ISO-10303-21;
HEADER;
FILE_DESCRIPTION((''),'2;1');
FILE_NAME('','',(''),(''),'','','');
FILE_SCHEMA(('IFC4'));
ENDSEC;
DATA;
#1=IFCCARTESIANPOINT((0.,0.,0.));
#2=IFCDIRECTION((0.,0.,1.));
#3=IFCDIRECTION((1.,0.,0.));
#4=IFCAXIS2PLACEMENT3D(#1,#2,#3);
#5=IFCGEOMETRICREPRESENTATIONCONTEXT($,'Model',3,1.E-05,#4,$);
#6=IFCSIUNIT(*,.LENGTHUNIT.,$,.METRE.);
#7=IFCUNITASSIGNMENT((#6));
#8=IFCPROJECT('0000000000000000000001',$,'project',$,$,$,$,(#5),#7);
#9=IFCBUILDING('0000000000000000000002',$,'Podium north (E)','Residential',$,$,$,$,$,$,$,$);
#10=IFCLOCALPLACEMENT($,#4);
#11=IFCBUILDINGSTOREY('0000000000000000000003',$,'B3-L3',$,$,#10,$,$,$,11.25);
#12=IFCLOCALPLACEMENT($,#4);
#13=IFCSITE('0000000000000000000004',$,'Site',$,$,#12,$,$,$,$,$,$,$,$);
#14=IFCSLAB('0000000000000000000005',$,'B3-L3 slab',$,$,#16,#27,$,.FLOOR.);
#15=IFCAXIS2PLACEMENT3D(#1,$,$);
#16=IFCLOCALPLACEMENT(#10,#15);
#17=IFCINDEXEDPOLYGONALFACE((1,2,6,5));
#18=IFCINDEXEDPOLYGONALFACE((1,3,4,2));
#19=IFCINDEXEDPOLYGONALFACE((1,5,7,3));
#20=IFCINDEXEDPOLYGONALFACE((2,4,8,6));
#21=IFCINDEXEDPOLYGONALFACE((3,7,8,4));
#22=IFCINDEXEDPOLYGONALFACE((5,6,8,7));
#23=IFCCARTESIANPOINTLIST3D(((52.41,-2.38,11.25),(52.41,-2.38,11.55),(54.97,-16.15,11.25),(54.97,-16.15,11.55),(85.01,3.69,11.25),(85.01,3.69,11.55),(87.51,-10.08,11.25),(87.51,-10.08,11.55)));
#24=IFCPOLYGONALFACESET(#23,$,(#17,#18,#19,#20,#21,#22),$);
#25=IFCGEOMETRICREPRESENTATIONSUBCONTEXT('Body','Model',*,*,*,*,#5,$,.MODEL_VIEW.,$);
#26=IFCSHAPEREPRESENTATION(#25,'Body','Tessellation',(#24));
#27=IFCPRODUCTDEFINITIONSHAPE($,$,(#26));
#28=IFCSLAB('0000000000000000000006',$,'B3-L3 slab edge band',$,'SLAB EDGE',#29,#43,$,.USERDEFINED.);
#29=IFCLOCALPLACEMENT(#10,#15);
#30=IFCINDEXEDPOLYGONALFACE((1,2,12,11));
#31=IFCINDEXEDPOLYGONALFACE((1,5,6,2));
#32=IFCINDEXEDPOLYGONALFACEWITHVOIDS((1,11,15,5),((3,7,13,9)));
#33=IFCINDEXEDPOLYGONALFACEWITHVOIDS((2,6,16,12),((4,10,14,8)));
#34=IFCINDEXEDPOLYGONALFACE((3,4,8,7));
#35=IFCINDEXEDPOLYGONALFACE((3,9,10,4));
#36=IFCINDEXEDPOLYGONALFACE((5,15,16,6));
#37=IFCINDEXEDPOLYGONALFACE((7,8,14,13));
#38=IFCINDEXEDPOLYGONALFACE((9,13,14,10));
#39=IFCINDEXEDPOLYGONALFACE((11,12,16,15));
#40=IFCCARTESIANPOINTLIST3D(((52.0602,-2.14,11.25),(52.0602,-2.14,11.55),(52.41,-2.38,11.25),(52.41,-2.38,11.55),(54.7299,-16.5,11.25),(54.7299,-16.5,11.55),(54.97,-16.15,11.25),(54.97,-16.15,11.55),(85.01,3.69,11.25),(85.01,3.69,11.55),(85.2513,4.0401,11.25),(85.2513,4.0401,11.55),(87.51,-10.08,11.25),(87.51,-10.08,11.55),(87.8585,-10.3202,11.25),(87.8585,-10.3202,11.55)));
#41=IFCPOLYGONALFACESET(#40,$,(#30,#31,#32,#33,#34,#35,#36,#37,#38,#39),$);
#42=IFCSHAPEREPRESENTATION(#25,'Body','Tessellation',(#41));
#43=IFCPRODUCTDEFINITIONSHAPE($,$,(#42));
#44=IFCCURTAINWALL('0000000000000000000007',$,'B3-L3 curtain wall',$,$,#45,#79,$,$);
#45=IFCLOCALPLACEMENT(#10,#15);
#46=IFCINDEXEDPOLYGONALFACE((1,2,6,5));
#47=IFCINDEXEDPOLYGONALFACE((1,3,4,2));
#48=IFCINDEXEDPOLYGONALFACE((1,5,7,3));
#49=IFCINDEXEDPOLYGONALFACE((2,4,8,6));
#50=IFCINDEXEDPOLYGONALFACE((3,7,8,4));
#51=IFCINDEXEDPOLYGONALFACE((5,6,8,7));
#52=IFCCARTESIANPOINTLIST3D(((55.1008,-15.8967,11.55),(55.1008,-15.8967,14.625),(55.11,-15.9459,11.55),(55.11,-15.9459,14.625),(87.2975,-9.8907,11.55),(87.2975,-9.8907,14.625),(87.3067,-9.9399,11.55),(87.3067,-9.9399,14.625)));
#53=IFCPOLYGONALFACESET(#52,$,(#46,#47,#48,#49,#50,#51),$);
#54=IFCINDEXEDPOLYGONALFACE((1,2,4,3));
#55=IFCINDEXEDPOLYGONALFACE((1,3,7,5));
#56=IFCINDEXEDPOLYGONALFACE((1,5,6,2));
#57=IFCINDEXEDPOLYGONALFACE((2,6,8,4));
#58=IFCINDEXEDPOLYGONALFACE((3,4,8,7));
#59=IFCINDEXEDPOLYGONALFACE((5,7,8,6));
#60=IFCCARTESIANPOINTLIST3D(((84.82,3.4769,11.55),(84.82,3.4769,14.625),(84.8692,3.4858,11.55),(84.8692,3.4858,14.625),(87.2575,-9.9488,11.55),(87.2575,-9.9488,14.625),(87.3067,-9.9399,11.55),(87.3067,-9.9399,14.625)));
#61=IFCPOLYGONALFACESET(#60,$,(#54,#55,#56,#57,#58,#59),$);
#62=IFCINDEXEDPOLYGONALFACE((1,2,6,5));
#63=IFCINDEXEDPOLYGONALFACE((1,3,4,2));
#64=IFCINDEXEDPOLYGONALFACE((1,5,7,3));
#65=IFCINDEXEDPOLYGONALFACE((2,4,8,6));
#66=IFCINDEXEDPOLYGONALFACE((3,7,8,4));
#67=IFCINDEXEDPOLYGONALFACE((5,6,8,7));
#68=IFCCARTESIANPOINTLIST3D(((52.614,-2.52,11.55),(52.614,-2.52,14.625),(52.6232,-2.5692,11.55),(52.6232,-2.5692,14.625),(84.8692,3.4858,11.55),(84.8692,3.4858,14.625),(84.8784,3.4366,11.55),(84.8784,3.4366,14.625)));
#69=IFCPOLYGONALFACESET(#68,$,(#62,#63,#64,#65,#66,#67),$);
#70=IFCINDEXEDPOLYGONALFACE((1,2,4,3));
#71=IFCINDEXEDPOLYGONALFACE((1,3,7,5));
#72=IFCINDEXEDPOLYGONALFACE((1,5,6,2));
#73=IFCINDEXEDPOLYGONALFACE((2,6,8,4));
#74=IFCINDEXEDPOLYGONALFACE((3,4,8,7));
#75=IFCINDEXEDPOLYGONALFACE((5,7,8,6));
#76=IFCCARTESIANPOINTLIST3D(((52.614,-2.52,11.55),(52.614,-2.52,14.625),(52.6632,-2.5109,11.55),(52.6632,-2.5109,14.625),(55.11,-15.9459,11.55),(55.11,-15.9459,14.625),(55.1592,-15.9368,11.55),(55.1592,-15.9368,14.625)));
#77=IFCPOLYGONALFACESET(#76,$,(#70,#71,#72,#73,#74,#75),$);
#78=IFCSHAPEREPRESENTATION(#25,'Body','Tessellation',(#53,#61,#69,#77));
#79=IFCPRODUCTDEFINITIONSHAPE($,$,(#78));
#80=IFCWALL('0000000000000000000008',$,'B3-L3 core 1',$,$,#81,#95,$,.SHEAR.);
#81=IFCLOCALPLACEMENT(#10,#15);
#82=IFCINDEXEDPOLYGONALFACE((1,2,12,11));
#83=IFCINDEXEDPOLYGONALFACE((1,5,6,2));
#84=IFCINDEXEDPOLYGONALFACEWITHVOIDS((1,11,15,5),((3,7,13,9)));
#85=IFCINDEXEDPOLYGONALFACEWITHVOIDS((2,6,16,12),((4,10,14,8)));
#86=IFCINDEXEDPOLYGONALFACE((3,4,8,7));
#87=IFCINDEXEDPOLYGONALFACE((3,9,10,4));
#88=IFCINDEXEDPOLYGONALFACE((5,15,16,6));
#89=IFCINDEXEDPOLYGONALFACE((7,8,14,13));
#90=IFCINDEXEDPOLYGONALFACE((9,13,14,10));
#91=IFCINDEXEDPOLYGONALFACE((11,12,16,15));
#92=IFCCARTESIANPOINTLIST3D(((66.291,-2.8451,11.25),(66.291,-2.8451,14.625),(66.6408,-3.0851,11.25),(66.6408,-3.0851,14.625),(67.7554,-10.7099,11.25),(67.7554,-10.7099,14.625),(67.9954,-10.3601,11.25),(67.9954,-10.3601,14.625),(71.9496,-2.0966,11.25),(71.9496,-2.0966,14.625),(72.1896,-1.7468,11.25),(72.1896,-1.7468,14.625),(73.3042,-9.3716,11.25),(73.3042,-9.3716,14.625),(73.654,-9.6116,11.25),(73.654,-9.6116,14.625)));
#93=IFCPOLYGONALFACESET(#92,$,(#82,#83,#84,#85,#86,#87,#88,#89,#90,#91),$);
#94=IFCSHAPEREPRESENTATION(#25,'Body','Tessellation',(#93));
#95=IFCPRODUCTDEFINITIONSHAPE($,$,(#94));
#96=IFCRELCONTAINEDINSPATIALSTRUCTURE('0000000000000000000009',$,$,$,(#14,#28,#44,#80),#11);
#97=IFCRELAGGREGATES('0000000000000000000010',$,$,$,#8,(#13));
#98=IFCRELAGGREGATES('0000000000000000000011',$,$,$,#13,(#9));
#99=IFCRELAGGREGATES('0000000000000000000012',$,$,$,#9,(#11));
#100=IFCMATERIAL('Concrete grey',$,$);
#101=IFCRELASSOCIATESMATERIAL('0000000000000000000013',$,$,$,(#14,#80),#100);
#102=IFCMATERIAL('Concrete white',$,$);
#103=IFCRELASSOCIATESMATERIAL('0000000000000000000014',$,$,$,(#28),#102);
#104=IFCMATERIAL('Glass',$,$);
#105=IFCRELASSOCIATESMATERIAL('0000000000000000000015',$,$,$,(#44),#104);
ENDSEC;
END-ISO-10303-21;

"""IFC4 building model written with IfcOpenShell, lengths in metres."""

from ifc_helpers import new_model, si_unit, frame, origin_with_axes, place, context, subcontext, project, spatial, polyline, outline, extrude, material, element, save


model = new_model("IFC4")

# Units and contexts
model_context = context("Model", 3, precision=1e-05, world=origin_with_axes())
body_context = subcontext(model_context, "Body", "Model", "MODEL_VIEW")
ifc_project = project(units=[si_unit("LENGTHUNIT", "METRE")], contexts=[model_context])

# Site, building, storey
site_placement = place(None, origin_with_axes())
site = spatial("IfcSite", under=ifc_project, at=site_placement, Name="Site")
building = spatial("IfcBuilding", under=site, Name="Podium north (E)", Description="Residential")
storey_placement = place(None, origin_with_axes())
storey = spatial("IfcBuildingStorey", under=building, at=storey_placement, Name="B3-L3", Elevation=11.25)

# Slabs
ifc_material_1 = material(Name="Concrete grey")
slab_1_placement = place(storey_placement, origin_with_axes())
element("IfcSlab", 1, at=slab_1_placement, inside=storey, material=ifc_material_1, Name="B3-L3 slab", PredefinedType="FLOOR", context=body_context, shape_type="SweptSolid", body=[
    extrude(outline(polyline([(54.97, -16.15), (87.51, -10.08), (85.01, 3.69), (52.41, -2.38), (54.97, -16.15)])), frame((0.0, 0.0, 11.25), z_axis=(0.0, 0.0, 1.0), x_axis=(1.0, 0.0, 0.0)), (0.0, 0.0, 1.0), 0.3),
])
ifc_material_2 = material(Name="Concrete white")
slab_2_placement = place(storey_placement, origin_with_axes())
element("IfcSlab", 2, at=slab_2_placement, inside=storey, material=ifc_material_2, Name="B3-L3 slab edge band", ObjectType="SLAB EDGE", PredefinedType="USERDEFINED", context=body_context, shape_type="SweptSolid", body=[
    extrude(outline(polyline([(54.7299, -16.5), (87.8585, -10.3202), (85.2513, 4.0401), (52.0602, -2.14), (54.7299, -16.5)]), holes=[polyline([(54.97, -16.15), (87.51, -10.08), (85.01, 3.69), (52.41, -2.38), (54.97, -16.15)])]), frame((0.0, 0.0, 11.25), z_axis=(0.0, 0.0, 1.0), x_axis=(1.0, 0.0, 0.0)), (0.0, 0.0, 1.0), 0.3),
])

# Curtain wall
ifc_material_3 = material(Name="Glass")
curtain_wall_placement = place(storey_placement, origin_with_axes())
element("IfcCurtainWall", 3, at=curtain_wall_placement, inside=storey, material=ifc_material_3, Name="B3-L3 curtain wall", context=body_context, shape_type="SweptSolid", body=[
    extrude(outline(polyline([(55.11, -15.9459), (87.3067, -9.9399), (87.2975, -9.8907), (55.1008, -15.8967), (55.11, -15.9459)])), frame((0.0, 0.0, 11.55), z_axis=(0.0, 0.0, 1.0), x_axis=(1.0, 0.0, 0.0)), (0.0, 0.0, 1.0), 3.075),
    extrude(outline(polyline([(87.3067, -9.9399), (84.8692, 3.4858), (84.82, 3.4769), (87.2575, -9.9488), (87.3067, -9.9399)])), frame((0.0, 0.0, 11.55), z_axis=(0.0, 0.0, 1.0), x_axis=(1.0, 0.0, 0.0)), (0.0, 0.0, 1.0), 3.075),
    extrude(outline(polyline([(84.8692, 3.4858), (52.614, -2.52), (52.6232, -2.5692), (84.8784, 3.4366), (84.8692, 3.4858)])), frame((0.0, 0.0, 11.55), z_axis=(0.0, 0.0, 1.0), x_axis=(1.0, 0.0, 0.0)), (0.0, 0.0, 1.0), 3.075),
    extrude(outline(polyline([(52.614, -2.52), (55.11, -15.9459), (55.1592, -15.9368), (52.6632, -2.5109), (52.614, -2.52)])), frame((0.0, 0.0, 11.55), z_axis=(0.0, 0.0, 1.0), x_axis=(1.0, 0.0, 0.0)), (0.0, 0.0, 1.0), 3.075),
])

# Wall
wall_placement = place(storey_placement, origin_with_axes())
element("IfcWall", 4, at=wall_placement, inside=storey, material=ifc_material_1, Name="B3-L3 core 1", PredefinedType="SHEAR", context=body_context, shape_type="SweptSolid", body=[
    extrude(outline(polyline([(72.1896, -1.7468), (66.291, -2.8451), (67.7554, -10.7099), (73.654, -9.6116), (72.1896, -1.7468)]), holes=[polyline([(71.9496, -2.0966), (66.6408, -3.0851), (67.9954, -10.3601), (73.3042, -9.3716), (71.9496, -2.0966)])]), frame((0.0, 0.0, 11.25), z_axis=(0.0, 0.0, 1.0), x_axis=(1.0, 0.0, 0.0)), (0.0, 0.0, 1.0), 3.375),
])

save(model, "model.ifc")
